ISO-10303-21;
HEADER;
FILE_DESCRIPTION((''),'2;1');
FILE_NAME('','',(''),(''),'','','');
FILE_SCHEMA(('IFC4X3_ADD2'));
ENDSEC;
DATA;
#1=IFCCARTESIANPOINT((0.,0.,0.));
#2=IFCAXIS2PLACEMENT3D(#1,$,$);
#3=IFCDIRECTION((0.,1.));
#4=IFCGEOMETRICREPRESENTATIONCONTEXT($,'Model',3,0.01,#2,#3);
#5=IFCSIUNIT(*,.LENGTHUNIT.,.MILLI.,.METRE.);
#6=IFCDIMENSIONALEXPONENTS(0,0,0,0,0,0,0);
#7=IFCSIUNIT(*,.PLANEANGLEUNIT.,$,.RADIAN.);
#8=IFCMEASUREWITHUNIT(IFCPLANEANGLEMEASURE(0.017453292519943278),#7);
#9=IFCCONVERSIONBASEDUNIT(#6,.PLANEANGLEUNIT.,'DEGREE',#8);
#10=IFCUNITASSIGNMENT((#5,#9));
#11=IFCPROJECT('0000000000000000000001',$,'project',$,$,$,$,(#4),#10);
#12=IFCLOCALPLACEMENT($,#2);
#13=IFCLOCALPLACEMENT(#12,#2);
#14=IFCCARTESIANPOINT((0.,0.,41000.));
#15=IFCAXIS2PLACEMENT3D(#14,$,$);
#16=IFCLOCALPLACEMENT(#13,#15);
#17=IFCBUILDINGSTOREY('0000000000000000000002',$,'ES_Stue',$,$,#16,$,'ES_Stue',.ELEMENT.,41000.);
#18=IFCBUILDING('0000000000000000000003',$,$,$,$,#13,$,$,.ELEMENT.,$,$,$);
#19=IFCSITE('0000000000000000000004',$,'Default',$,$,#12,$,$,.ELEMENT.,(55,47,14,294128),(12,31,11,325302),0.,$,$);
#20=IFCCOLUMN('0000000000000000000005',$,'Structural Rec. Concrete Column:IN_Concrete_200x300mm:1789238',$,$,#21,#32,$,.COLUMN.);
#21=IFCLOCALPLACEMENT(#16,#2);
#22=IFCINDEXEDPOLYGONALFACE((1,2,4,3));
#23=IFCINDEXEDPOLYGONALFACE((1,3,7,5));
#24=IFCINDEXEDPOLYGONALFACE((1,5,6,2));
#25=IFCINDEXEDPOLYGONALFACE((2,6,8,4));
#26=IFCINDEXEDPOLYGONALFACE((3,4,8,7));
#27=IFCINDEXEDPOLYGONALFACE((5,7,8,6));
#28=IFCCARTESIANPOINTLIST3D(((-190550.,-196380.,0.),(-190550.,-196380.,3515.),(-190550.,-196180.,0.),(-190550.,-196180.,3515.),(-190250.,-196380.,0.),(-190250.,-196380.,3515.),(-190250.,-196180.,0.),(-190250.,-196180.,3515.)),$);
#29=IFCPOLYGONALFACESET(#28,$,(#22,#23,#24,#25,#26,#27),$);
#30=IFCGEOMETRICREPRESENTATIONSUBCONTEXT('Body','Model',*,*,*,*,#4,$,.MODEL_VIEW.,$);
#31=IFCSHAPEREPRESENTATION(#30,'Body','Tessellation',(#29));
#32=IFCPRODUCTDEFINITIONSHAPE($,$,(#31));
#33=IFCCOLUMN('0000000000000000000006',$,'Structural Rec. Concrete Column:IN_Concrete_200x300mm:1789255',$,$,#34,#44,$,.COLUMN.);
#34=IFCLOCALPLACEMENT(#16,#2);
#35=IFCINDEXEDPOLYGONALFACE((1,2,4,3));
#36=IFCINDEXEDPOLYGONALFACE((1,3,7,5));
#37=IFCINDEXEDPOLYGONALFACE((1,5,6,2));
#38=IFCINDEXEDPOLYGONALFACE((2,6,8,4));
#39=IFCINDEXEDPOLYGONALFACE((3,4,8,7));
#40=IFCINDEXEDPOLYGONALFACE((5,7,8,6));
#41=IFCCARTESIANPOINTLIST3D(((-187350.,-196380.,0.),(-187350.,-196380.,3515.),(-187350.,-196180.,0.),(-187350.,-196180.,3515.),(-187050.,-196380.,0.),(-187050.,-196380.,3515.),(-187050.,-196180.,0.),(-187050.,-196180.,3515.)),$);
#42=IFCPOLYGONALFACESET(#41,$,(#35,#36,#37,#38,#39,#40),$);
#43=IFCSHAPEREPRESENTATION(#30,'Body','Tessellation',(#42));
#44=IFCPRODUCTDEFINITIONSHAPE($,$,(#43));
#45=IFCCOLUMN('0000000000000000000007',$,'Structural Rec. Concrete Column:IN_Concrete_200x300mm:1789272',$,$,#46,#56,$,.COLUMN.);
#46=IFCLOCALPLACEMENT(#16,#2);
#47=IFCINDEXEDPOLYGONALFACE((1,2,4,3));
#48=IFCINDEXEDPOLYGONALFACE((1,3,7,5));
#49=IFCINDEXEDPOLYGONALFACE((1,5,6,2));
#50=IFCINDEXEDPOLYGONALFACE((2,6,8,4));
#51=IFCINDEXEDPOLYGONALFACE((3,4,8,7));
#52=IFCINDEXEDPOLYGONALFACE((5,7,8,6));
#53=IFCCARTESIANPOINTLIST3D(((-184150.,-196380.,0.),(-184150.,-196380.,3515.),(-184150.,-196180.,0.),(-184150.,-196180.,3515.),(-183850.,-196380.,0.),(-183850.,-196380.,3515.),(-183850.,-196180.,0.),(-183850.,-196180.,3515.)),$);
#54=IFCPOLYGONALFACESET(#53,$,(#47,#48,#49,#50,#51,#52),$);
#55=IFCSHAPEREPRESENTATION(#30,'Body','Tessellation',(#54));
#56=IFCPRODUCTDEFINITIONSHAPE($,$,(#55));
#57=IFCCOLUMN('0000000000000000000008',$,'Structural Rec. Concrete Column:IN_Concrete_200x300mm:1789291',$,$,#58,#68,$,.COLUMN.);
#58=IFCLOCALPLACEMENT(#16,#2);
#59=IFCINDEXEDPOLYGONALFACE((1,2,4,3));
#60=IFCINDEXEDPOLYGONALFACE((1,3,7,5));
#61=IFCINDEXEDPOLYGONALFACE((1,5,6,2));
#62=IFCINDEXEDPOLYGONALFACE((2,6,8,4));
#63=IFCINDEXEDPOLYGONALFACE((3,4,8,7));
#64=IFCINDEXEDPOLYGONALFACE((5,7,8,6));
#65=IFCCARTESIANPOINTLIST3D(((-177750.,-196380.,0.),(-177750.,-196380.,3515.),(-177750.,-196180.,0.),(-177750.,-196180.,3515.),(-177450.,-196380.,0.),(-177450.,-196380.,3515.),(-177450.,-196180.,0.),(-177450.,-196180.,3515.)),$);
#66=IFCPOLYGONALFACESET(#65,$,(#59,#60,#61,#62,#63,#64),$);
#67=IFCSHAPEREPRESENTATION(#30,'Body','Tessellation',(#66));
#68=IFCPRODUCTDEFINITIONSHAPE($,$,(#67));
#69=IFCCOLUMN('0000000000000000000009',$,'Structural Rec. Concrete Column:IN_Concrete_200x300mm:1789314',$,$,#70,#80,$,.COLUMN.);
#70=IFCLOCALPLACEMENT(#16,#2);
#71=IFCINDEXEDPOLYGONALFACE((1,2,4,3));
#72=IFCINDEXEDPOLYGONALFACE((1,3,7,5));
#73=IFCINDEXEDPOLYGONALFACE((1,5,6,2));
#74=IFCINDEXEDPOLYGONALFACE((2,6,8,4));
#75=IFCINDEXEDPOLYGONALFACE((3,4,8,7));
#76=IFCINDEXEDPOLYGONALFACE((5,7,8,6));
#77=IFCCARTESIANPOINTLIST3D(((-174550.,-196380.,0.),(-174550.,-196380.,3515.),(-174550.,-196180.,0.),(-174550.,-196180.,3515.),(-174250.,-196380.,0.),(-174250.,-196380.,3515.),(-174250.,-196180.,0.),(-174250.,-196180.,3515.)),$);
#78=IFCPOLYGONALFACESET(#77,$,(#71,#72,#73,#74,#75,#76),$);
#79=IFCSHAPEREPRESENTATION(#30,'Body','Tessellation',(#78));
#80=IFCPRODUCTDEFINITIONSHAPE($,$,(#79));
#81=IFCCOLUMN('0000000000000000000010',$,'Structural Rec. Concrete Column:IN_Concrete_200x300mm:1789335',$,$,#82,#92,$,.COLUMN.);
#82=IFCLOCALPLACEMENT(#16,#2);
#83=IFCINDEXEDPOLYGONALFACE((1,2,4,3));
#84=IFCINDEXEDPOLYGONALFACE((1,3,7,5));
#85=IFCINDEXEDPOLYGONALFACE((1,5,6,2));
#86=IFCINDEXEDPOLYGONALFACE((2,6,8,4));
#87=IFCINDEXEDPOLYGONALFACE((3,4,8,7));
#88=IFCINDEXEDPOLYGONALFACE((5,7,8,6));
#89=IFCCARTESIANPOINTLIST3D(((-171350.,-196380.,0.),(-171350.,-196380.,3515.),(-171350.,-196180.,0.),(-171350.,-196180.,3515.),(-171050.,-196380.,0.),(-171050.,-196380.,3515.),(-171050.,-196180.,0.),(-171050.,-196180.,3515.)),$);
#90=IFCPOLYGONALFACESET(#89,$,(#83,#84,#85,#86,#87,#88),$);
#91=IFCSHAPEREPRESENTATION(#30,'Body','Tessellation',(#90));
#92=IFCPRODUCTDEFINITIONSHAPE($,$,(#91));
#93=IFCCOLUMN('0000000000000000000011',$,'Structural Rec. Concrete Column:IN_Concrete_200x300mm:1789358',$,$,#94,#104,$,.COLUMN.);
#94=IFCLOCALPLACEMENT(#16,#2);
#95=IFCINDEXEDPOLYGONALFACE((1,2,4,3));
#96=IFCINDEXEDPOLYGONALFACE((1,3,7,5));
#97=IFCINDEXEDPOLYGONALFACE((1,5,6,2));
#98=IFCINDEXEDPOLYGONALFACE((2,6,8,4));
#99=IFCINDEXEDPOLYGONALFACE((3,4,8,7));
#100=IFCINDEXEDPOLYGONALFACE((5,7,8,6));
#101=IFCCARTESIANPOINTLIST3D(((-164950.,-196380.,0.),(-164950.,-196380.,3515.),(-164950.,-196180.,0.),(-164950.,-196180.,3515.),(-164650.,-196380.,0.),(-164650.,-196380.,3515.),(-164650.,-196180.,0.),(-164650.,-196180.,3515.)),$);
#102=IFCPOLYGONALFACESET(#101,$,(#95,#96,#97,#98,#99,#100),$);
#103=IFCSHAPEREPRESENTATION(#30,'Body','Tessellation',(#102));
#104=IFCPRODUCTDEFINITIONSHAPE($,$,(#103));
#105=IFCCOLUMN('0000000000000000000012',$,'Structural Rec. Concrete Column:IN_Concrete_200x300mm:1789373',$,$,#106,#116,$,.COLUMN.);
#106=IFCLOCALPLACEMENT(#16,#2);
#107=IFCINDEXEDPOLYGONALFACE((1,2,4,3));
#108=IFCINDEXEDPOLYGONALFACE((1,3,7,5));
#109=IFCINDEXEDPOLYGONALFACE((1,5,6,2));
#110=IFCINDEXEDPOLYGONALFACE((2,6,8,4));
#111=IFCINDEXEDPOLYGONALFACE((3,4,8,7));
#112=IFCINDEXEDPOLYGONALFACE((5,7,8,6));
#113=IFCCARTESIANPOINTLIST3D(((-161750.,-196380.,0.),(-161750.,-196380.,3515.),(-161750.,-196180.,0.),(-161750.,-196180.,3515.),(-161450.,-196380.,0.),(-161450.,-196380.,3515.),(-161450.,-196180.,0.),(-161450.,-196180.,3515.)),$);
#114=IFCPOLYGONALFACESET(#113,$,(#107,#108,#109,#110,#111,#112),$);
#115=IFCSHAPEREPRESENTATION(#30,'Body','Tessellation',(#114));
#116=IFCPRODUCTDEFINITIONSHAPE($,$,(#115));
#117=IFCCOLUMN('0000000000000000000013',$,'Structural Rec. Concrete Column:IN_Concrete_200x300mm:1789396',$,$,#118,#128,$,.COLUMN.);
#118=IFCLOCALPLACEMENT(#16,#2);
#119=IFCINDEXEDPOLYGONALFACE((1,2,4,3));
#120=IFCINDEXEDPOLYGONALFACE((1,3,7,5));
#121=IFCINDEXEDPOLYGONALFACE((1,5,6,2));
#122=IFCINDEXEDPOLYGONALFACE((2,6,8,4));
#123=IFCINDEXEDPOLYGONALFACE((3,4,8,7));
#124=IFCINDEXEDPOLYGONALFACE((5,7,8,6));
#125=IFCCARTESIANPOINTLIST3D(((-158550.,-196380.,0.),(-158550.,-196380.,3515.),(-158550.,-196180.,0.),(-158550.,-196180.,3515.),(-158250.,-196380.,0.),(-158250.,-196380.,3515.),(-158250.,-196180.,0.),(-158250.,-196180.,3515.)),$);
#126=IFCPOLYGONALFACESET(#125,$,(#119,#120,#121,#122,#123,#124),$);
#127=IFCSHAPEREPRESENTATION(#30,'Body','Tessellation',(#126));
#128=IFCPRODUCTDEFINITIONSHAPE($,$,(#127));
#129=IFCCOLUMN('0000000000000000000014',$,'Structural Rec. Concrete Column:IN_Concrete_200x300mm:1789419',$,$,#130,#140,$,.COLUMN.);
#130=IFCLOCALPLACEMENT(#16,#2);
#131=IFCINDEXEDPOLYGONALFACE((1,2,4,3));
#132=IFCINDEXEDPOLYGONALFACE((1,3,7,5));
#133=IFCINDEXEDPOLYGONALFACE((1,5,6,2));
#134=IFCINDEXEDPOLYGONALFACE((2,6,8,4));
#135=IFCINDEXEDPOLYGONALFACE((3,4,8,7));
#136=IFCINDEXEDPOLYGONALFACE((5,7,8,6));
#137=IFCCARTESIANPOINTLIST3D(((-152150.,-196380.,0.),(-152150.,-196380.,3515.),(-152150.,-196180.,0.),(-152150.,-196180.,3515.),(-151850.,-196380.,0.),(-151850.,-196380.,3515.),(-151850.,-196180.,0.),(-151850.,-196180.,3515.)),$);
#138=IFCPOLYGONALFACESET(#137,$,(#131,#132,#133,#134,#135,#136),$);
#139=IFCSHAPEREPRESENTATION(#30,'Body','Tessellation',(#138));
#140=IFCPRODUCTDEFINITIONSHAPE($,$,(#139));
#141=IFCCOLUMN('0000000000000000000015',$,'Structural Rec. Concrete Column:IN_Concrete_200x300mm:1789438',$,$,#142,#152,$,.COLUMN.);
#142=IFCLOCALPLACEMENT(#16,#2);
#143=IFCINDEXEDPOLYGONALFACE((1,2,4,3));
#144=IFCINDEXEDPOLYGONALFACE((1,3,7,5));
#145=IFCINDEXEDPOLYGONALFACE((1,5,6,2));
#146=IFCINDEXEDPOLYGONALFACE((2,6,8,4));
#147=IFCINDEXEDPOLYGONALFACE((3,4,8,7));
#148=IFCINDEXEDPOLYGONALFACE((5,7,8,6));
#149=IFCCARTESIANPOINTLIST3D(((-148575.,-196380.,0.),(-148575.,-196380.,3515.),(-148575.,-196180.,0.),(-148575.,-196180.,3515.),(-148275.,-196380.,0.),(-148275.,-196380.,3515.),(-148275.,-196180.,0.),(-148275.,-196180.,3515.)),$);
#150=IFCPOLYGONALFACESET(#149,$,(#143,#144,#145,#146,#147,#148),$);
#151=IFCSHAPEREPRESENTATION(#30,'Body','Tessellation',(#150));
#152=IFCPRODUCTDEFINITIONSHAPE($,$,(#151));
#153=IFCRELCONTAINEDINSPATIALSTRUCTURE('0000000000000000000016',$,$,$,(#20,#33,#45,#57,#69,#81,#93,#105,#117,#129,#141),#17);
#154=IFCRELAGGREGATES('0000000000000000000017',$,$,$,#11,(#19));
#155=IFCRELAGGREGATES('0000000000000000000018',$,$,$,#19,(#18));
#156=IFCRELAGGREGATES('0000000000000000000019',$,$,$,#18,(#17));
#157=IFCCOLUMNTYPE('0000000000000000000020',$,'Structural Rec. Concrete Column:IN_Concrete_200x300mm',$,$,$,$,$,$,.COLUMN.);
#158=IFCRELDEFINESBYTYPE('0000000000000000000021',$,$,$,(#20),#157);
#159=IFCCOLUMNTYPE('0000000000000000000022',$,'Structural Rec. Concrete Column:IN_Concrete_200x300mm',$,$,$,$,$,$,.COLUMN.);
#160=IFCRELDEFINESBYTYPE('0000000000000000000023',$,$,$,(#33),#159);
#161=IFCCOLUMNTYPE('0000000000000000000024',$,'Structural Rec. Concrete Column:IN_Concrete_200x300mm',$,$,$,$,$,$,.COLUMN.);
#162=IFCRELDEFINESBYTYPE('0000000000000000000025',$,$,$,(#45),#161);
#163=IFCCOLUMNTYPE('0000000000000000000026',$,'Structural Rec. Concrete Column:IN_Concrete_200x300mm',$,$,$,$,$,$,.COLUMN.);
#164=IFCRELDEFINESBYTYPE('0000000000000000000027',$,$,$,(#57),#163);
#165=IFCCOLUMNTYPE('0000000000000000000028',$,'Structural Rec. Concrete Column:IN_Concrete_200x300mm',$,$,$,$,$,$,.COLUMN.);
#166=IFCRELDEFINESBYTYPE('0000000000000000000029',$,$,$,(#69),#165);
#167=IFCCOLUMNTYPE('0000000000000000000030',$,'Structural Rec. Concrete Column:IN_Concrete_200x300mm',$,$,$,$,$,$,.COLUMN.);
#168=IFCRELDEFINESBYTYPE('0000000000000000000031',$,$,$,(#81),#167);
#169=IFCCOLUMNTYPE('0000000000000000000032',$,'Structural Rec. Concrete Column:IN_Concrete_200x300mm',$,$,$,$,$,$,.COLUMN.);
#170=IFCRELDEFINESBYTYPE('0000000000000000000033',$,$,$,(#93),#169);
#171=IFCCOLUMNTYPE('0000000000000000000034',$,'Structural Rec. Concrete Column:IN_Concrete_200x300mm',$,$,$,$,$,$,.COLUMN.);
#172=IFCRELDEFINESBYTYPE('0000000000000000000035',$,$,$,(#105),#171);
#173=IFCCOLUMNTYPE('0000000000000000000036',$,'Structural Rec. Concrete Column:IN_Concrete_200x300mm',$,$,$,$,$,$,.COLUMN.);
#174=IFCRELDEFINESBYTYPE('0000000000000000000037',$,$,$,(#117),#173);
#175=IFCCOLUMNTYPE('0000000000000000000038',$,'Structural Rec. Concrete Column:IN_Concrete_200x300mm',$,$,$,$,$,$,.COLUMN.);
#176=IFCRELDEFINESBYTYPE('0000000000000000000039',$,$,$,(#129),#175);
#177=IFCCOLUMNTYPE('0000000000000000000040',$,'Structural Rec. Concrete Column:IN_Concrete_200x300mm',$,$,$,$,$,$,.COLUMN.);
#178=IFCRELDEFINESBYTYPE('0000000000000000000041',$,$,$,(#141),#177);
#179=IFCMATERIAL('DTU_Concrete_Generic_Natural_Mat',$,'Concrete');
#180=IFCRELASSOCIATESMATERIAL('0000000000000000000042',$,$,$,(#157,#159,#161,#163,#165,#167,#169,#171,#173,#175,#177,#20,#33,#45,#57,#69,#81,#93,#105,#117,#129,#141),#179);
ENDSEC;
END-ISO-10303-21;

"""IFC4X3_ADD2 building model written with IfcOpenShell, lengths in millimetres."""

from ifc_helpers import new_model, entity, si_unit, converted_unit, direction, frame, frame_2d, origin, place, context, subcontext, project, spatial, rectangle, extrude, source, transform, mapped, material, material_profile, profile_set, profile_usage, type_object, type_shapes, element, save


model = new_model("IFC4X3_ADD2")

# Units and contexts
model_context = context("Model", 3, precision=0.01, world=origin(), true_north=direction((0.0, 1.0)))
body_context = subcontext(model_context, "Body", "Model", "MODEL_VIEW")
ifc_project = project(units=[si_unit("LENGTHUNIT", "METRE", prefix="MILLI"), converted_unit("PLANEANGLEUNIT", "DEGREE", entity("IfcPlaneAngleMeasure", 0.017453292519943278), si_unit("PLANEANGLEUNIT", "RADIAN"), dimensions=[0, 0, 0, 0, 0, 0, 0])], contexts=[model_context])

# Site, building, storey
site_placement = place(None, origin())
site = spatial("IfcSite", under=ifc_project, at=site_placement, Name="Default", CompositionType="ELEMENT", RefLatitude=(55, 47, 14, 294128), RefLongitude=(12, 31, 11, 325302), RefElevation=0.0)
building_placement = place(site_placement, origin())
building = spatial("IfcBuilding", under=site, at=building_placement, CompositionType="ELEMENT")
storey_placement = place(building_placement, frame((0.0, 0.0, 41000.0)))
storey = spatial("IfcBuildingStorey", under=building, at=storey_placement, Name="ES_Stue", LongName="ES_Stue", CompositionType="ELEMENT", Elevation=41000.0)

# Columns
ifc_material = material(Name="DTU_Concrete_Generic_Natural_Mat", Category="Concrete")
ifc_material_profile_1 = material_profile(ifc_material, rectangle(XDim=200.0, YDim=300.0, at=frame_2d((0.0, 0.0), x_axis=(1.0, 0.0))), Name="IN_Concrete_200x300mm")
ifc_profile_set_1 = profile_set([ifc_material_profile_1], Name="IN_Concrete_200x300mm")
ifc_profile_usage_1 = profile_usage(ifc_profile_set_1)
column_type_1 = type_object("IfcColumnType", Name="Structural Rec. Concrete Column:IN_Concrete_200x300mm", PredefinedType="COLUMN", material=ifc_profile_set_1)
shared_shape_1 = source(origin(), body_context, "Body", "SweptSolid", [
    extrude(rectangle(XDim=200.0, YDim=300.0, at=frame_2d((0.0, 0.0), x_axis=(1.0, 0.0))), frame((-190400.0, -196280.0, 41000.0), z_axis=(0.0, 0.0, 1.0), x_axis=(0.0, -1.0, 0.0)), (0.0, 0.0, 1.0), 3515.0),
])
type_shapes(column_type_1, [shared_shape_1])
column_1_placement = place(storey_placement, frame((0.0, 0.0, -41000.0)))
element("IfcColumn", 1, at=column_1_placement, inside=storey, type_object=column_type_1, material=ifc_profile_usage_1, Name="Structural Rec. Concrete Column:IN_Concrete_200x300mm:1789238", PredefinedType="COLUMN", context=body_context, shape_type="MappedRepresentation", body=[
    mapped(shared_shape_1, transform((0.0, 0.0, 0.0), scale=1.0)),
])
column_type_2 = type_object("IfcColumnType", Name="Structural Rec. Concrete Column:IN_Concrete_200x300mm", PredefinedType="COLUMN", material=ifc_profile_set_1)
shared_shape_2 = source(origin(), body_context, "Body", "SweptSolid", [
    extrude(rectangle(XDim=200.0, YDim=300.0, at=frame_2d((0.0, 0.0), x_axis=(1.0, 0.0))), frame((-187200.0, -196280.0, 41000.0), z_axis=(0.0, 0.0, 1.0), x_axis=(0.0, -1.0, 0.0)), (0.0, 0.0, 1.0), 3515.0),
])
type_shapes(column_type_2, [shared_shape_2])
column_2_placement = place(storey_placement, frame((0.0, 0.0, -41000.0)))
element("IfcColumn", 2, at=column_2_placement, inside=storey, type_object=column_type_2, material=ifc_profile_usage_1, Name="Structural Rec. Concrete Column:IN_Concrete_200x300mm:1789255", PredefinedType="COLUMN", context=body_context, shape_type="MappedRepresentation", body=[
    mapped(shared_shape_2, transform((0.0, 0.0, 0.0), scale=1.0)),
])
column_type_3 = type_object("IfcColumnType", Name="Structural Rec. Concrete Column:IN_Concrete_200x300mm", PredefinedType="COLUMN", material=ifc_profile_set_1)
shared_shape_3 = source(origin(), body_context, "Body", "SweptSolid", [
    extrude(rectangle(XDim=200.0, YDim=300.0, at=frame_2d((0.0, 0.0), x_axis=(1.0, 0.0))), frame((-184000.0, -196280.0, 41000.0), z_axis=(0.0, 0.0, 1.0), x_axis=(0.0, -1.0, 0.0)), (0.0, 0.0, 1.0), 3515.0),
])
type_shapes(column_type_3, [shared_shape_3])
column_3_placement = place(storey_placement, frame((0.0, 0.0, -41000.0)))
element("IfcColumn", 3, at=column_3_placement, inside=storey, type_object=column_type_3, material=ifc_profile_usage_1, Name="Structural Rec. Concrete Column:IN_Concrete_200x300mm:1789272", PredefinedType="COLUMN", context=body_context, shape_type="MappedRepresentation", body=[
    mapped(shared_shape_3, transform((0.0, 0.0, 0.0), scale=1.0)),
])
column_type_4 = type_object("IfcColumnType", Name="Structural Rec. Concrete Column:IN_Concrete_200x300mm", PredefinedType="COLUMN", material=ifc_profile_set_1)
shared_shape_4 = source(origin(), body_context, "Body", "SweptSolid", [
    extrude(rectangle(XDim=200.0, YDim=300.0, at=frame_2d((0.0, 0.0), x_axis=(1.0, 0.0))), frame((-177600.0, -196280.0, 41000.0), z_axis=(0.0, 0.0, 1.0), x_axis=(0.0, -1.0, 0.0)), (0.0, 0.0, 1.0), 3515.0),
])
type_shapes(column_type_4, [shared_shape_4])
column_4_placement = place(storey_placement, frame((0.0, 0.0, -41000.0)))
element("IfcColumn", 4, at=column_4_placement, inside=storey, type_object=column_type_4, material=ifc_profile_usage_1, Name="Structural Rec. Concrete Column:IN_Concrete_200x300mm:1789291", PredefinedType="COLUMN", context=body_context, shape_type="MappedRepresentation", body=[
    mapped(shared_shape_4, transform((0.0, 0.0, 0.0), scale=1.0)),
])
column_type_5 = type_object("IfcColumnType", Name="Structural Rec. Concrete Column:IN_Concrete_200x300mm", PredefinedType="COLUMN", material=ifc_profile_set_1)
shared_shape_5 = source(origin(), body_context, "Body", "SweptSolid", [
    extrude(rectangle(XDim=200.0, YDim=300.0, at=frame_2d((0.0, 0.0), x_axis=(1.0, 0.0))), frame((-174400.0, -196280.0, 41000.0), z_axis=(0.0, 0.0, 1.0), x_axis=(0.0, -1.0, 0.0)), (0.0, 0.0, 1.0), 3515.0),
])
type_shapes(column_type_5, [shared_shape_5])
column_5_placement = place(storey_placement, frame((0.0, 0.0, -41000.0)))
element("IfcColumn", 5, at=column_5_placement, inside=storey, type_object=column_type_5, material=ifc_profile_usage_1, Name="Structural Rec. Concrete Column:IN_Concrete_200x300mm:1789314", PredefinedType="COLUMN", context=body_context, shape_type="MappedRepresentation", body=[
    mapped(shared_shape_5, transform((0.0, 0.0, 0.0), scale=1.0)),
])
column_type_6 = type_object("IfcColumnType", Name="Structural Rec. Concrete Column:IN_Concrete_200x300mm", PredefinedType="COLUMN", material=ifc_profile_set_1)
shared_shape_6 = source(origin(), body_context, "Body", "SweptSolid", [
    extrude(rectangle(XDim=200.0, YDim=300.0, at=frame_2d((0.0, 0.0), x_axis=(1.0, 0.0))), frame((-171200.0, -196280.0, 41000.0), z_axis=(0.0, 0.0, 1.0), x_axis=(0.0, -1.0, 0.0)), (0.0, 0.0, 1.0), 3515.0),
])
type_shapes(column_type_6, [shared_shape_6])
column_6_placement = place(storey_placement, frame((0.0, 0.0, -41000.0)))
element("IfcColumn", 6, at=column_6_placement, inside=storey, type_object=column_type_6, material=ifc_profile_usage_1, Name="Structural Rec. Concrete Column:IN_Concrete_200x300mm:1789335", PredefinedType="COLUMN", context=body_context, shape_type="MappedRepresentation", body=[
    mapped(shared_shape_6, transform((0.0, 0.0, 0.0), scale=1.0)),
])
column_type_7 = type_object("IfcColumnType", Name="Structural Rec. Concrete Column:IN_Concrete_200x300mm", PredefinedType="COLUMN", material=ifc_profile_set_1)
shared_shape_7 = source(origin(), body_context, "Body", "SweptSolid", [
    extrude(rectangle(XDim=200.0, YDim=300.0, at=frame_2d((0.0, 0.0), x_axis=(1.0, 0.0))), frame((-164800.0, -196280.0, 41000.0), z_axis=(0.0, 0.0, 1.0), x_axis=(0.0, -1.0, 0.0)), (0.0, 0.0, 1.0), 3515.0),
])
type_shapes(column_type_7, [shared_shape_7])
column_7_placement = place(storey_placement, frame((0.0, 0.0, -41000.0)))
element("IfcColumn", 7, at=column_7_placement, inside=storey, type_object=column_type_7, material=ifc_profile_usage_1, Name="Structural Rec. Concrete Column:IN_Concrete_200x300mm:1789358", PredefinedType="COLUMN", context=body_context, shape_type="MappedRepresentation", body=[
    mapped(shared_shape_7, transform((0.0, 0.0, 0.0), scale=1.0)),
])
column_type_8 = type_object("IfcColumnType", Name="Structural Rec. Concrete Column:IN_Concrete_200x300mm", PredefinedType="COLUMN", material=ifc_profile_set_1)
shared_shape_8 = source(origin(), body_context, "Body", "SweptSolid", [
    extrude(rectangle(XDim=200.0, YDim=300.0, at=frame_2d((0.0, 0.0), x_axis=(1.0, 0.0))), frame((-161600.0, -196280.0, 41000.0), z_axis=(0.0, 0.0, 1.0), x_axis=(0.0, -1.0, 0.0)), (0.0, 0.0, 1.0), 3515.0),
])
type_shapes(column_type_8, [shared_shape_8])
column_8_placement = place(storey_placement, frame((0.0, 0.0, -41000.0)))
element("IfcColumn", 8, at=column_8_placement, inside=storey, type_object=column_type_8, material=ifc_profile_usage_1, Name="Structural Rec. Concrete Column:IN_Concrete_200x300mm:1789373", PredefinedType="COLUMN", context=body_context, shape_type="MappedRepresentation", body=[
    mapped(shared_shape_8, transform((0.0, 0.0, 0.0), scale=1.0)),
])
column_type_9 = type_object("IfcColumnType", Name="Structural Rec. Concrete Column:IN_Concrete_200x300mm", PredefinedType="COLUMN", material=ifc_profile_set_1)
shared_shape_9 = source(origin(), body_context, "Body", "SweptSolid", [
    extrude(rectangle(XDim=200.0, YDim=300.0, at=frame_2d((0.0, 0.0), x_axis=(1.0, 0.0))), frame((-158400.0, -196280.0, 41000.0), z_axis=(0.0, 0.0, 1.0), x_axis=(0.0, -1.0, 0.0)), (0.0, 0.0, 1.0), 3515.0),
])
type_shapes(column_type_9, [shared_shape_9])
column_9_placement = place(storey_placement, frame((0.0, 0.0, -41000.0)))
element("IfcColumn", 9, at=column_9_placement, inside=storey, type_object=column_type_9, material=ifc_profile_usage_1, Name="Structural Rec. Concrete Column:IN_Concrete_200x300mm:1789396", PredefinedType="COLUMN", context=body_context, shape_type="MappedRepresentation", body=[
    mapped(shared_shape_9, transform((0.0, 0.0, 0.0), scale=1.0)),
])
column_type_10 = type_object("IfcColumnType", Name="Structural Rec. Concrete Column:IN_Concrete_200x300mm", PredefinedType="COLUMN", material=ifc_profile_set_1)
shared_shape_10 = source(origin(), body_context, "Body", "SweptSolid", [
    extrude(rectangle(XDim=200.0, YDim=300.0, at=frame_2d((0.0, 0.0), x_axis=(1.0, 0.0))), frame((-152000.0, -196280.0, 41000.0), z_axis=(0.0, 0.0, 1.0), x_axis=(0.0, -1.0, 0.0)), (0.0, 0.0, 1.0), 3515.0),
])
type_shapes(column_type_10, [shared_shape_10])
column_10_placement = place(storey_placement, frame((0.0, 0.0, -41000.0)))
element("IfcColumn", 10, at=column_10_placement, inside=storey, type_object=column_type_10, material=ifc_profile_usage_1, Name="Structural Rec. Concrete Column:IN_Concrete_200x300mm:1789419", PredefinedType="COLUMN", context=body_context, shape_type="MappedRepresentation", body=[
    mapped(shared_shape_10, transform((0.0, 0.0, 0.0), scale=1.0)),
])
column_type_11 = type_object("IfcColumnType", Name="Structural Rec. Concrete Column:IN_Concrete_200x300mm", PredefinedType="COLUMN", material=ifc_profile_set_1)
shared_shape_11 = source(origin(), body_context, "Body", "SweptSolid", [
    extrude(rectangle(XDim=200.0, YDim=300.0, at=frame_2d((0.0, 0.0), x_axis=(1.0, 0.0))), frame((-148425.0, -196280.0, 41000.0), z_axis=(0.0, 0.0, 1.0), x_axis=(0.0, -1.0, 0.0)), (0.0, 0.0, 1.0), 3515.0),
])
type_shapes(column_type_11, [shared_shape_11])
column_11_placement = place(storey_placement, frame((0.0, 0.0, -41000.0)))
element("IfcColumn", 11, at=column_11_placement, inside=storey, type_object=column_type_11, material=ifc_profile_usage_1, Name="Structural Rec. Concrete Column:IN_Concrete_200x300mm:1789438", PredefinedType="COLUMN", context=body_context, shape_type="MappedRepresentation", body=[
    mapped(shared_shape_11, transform((0.0, 0.0, 0.0), scale=1.0)),
])

save(model, "model.ifc")
